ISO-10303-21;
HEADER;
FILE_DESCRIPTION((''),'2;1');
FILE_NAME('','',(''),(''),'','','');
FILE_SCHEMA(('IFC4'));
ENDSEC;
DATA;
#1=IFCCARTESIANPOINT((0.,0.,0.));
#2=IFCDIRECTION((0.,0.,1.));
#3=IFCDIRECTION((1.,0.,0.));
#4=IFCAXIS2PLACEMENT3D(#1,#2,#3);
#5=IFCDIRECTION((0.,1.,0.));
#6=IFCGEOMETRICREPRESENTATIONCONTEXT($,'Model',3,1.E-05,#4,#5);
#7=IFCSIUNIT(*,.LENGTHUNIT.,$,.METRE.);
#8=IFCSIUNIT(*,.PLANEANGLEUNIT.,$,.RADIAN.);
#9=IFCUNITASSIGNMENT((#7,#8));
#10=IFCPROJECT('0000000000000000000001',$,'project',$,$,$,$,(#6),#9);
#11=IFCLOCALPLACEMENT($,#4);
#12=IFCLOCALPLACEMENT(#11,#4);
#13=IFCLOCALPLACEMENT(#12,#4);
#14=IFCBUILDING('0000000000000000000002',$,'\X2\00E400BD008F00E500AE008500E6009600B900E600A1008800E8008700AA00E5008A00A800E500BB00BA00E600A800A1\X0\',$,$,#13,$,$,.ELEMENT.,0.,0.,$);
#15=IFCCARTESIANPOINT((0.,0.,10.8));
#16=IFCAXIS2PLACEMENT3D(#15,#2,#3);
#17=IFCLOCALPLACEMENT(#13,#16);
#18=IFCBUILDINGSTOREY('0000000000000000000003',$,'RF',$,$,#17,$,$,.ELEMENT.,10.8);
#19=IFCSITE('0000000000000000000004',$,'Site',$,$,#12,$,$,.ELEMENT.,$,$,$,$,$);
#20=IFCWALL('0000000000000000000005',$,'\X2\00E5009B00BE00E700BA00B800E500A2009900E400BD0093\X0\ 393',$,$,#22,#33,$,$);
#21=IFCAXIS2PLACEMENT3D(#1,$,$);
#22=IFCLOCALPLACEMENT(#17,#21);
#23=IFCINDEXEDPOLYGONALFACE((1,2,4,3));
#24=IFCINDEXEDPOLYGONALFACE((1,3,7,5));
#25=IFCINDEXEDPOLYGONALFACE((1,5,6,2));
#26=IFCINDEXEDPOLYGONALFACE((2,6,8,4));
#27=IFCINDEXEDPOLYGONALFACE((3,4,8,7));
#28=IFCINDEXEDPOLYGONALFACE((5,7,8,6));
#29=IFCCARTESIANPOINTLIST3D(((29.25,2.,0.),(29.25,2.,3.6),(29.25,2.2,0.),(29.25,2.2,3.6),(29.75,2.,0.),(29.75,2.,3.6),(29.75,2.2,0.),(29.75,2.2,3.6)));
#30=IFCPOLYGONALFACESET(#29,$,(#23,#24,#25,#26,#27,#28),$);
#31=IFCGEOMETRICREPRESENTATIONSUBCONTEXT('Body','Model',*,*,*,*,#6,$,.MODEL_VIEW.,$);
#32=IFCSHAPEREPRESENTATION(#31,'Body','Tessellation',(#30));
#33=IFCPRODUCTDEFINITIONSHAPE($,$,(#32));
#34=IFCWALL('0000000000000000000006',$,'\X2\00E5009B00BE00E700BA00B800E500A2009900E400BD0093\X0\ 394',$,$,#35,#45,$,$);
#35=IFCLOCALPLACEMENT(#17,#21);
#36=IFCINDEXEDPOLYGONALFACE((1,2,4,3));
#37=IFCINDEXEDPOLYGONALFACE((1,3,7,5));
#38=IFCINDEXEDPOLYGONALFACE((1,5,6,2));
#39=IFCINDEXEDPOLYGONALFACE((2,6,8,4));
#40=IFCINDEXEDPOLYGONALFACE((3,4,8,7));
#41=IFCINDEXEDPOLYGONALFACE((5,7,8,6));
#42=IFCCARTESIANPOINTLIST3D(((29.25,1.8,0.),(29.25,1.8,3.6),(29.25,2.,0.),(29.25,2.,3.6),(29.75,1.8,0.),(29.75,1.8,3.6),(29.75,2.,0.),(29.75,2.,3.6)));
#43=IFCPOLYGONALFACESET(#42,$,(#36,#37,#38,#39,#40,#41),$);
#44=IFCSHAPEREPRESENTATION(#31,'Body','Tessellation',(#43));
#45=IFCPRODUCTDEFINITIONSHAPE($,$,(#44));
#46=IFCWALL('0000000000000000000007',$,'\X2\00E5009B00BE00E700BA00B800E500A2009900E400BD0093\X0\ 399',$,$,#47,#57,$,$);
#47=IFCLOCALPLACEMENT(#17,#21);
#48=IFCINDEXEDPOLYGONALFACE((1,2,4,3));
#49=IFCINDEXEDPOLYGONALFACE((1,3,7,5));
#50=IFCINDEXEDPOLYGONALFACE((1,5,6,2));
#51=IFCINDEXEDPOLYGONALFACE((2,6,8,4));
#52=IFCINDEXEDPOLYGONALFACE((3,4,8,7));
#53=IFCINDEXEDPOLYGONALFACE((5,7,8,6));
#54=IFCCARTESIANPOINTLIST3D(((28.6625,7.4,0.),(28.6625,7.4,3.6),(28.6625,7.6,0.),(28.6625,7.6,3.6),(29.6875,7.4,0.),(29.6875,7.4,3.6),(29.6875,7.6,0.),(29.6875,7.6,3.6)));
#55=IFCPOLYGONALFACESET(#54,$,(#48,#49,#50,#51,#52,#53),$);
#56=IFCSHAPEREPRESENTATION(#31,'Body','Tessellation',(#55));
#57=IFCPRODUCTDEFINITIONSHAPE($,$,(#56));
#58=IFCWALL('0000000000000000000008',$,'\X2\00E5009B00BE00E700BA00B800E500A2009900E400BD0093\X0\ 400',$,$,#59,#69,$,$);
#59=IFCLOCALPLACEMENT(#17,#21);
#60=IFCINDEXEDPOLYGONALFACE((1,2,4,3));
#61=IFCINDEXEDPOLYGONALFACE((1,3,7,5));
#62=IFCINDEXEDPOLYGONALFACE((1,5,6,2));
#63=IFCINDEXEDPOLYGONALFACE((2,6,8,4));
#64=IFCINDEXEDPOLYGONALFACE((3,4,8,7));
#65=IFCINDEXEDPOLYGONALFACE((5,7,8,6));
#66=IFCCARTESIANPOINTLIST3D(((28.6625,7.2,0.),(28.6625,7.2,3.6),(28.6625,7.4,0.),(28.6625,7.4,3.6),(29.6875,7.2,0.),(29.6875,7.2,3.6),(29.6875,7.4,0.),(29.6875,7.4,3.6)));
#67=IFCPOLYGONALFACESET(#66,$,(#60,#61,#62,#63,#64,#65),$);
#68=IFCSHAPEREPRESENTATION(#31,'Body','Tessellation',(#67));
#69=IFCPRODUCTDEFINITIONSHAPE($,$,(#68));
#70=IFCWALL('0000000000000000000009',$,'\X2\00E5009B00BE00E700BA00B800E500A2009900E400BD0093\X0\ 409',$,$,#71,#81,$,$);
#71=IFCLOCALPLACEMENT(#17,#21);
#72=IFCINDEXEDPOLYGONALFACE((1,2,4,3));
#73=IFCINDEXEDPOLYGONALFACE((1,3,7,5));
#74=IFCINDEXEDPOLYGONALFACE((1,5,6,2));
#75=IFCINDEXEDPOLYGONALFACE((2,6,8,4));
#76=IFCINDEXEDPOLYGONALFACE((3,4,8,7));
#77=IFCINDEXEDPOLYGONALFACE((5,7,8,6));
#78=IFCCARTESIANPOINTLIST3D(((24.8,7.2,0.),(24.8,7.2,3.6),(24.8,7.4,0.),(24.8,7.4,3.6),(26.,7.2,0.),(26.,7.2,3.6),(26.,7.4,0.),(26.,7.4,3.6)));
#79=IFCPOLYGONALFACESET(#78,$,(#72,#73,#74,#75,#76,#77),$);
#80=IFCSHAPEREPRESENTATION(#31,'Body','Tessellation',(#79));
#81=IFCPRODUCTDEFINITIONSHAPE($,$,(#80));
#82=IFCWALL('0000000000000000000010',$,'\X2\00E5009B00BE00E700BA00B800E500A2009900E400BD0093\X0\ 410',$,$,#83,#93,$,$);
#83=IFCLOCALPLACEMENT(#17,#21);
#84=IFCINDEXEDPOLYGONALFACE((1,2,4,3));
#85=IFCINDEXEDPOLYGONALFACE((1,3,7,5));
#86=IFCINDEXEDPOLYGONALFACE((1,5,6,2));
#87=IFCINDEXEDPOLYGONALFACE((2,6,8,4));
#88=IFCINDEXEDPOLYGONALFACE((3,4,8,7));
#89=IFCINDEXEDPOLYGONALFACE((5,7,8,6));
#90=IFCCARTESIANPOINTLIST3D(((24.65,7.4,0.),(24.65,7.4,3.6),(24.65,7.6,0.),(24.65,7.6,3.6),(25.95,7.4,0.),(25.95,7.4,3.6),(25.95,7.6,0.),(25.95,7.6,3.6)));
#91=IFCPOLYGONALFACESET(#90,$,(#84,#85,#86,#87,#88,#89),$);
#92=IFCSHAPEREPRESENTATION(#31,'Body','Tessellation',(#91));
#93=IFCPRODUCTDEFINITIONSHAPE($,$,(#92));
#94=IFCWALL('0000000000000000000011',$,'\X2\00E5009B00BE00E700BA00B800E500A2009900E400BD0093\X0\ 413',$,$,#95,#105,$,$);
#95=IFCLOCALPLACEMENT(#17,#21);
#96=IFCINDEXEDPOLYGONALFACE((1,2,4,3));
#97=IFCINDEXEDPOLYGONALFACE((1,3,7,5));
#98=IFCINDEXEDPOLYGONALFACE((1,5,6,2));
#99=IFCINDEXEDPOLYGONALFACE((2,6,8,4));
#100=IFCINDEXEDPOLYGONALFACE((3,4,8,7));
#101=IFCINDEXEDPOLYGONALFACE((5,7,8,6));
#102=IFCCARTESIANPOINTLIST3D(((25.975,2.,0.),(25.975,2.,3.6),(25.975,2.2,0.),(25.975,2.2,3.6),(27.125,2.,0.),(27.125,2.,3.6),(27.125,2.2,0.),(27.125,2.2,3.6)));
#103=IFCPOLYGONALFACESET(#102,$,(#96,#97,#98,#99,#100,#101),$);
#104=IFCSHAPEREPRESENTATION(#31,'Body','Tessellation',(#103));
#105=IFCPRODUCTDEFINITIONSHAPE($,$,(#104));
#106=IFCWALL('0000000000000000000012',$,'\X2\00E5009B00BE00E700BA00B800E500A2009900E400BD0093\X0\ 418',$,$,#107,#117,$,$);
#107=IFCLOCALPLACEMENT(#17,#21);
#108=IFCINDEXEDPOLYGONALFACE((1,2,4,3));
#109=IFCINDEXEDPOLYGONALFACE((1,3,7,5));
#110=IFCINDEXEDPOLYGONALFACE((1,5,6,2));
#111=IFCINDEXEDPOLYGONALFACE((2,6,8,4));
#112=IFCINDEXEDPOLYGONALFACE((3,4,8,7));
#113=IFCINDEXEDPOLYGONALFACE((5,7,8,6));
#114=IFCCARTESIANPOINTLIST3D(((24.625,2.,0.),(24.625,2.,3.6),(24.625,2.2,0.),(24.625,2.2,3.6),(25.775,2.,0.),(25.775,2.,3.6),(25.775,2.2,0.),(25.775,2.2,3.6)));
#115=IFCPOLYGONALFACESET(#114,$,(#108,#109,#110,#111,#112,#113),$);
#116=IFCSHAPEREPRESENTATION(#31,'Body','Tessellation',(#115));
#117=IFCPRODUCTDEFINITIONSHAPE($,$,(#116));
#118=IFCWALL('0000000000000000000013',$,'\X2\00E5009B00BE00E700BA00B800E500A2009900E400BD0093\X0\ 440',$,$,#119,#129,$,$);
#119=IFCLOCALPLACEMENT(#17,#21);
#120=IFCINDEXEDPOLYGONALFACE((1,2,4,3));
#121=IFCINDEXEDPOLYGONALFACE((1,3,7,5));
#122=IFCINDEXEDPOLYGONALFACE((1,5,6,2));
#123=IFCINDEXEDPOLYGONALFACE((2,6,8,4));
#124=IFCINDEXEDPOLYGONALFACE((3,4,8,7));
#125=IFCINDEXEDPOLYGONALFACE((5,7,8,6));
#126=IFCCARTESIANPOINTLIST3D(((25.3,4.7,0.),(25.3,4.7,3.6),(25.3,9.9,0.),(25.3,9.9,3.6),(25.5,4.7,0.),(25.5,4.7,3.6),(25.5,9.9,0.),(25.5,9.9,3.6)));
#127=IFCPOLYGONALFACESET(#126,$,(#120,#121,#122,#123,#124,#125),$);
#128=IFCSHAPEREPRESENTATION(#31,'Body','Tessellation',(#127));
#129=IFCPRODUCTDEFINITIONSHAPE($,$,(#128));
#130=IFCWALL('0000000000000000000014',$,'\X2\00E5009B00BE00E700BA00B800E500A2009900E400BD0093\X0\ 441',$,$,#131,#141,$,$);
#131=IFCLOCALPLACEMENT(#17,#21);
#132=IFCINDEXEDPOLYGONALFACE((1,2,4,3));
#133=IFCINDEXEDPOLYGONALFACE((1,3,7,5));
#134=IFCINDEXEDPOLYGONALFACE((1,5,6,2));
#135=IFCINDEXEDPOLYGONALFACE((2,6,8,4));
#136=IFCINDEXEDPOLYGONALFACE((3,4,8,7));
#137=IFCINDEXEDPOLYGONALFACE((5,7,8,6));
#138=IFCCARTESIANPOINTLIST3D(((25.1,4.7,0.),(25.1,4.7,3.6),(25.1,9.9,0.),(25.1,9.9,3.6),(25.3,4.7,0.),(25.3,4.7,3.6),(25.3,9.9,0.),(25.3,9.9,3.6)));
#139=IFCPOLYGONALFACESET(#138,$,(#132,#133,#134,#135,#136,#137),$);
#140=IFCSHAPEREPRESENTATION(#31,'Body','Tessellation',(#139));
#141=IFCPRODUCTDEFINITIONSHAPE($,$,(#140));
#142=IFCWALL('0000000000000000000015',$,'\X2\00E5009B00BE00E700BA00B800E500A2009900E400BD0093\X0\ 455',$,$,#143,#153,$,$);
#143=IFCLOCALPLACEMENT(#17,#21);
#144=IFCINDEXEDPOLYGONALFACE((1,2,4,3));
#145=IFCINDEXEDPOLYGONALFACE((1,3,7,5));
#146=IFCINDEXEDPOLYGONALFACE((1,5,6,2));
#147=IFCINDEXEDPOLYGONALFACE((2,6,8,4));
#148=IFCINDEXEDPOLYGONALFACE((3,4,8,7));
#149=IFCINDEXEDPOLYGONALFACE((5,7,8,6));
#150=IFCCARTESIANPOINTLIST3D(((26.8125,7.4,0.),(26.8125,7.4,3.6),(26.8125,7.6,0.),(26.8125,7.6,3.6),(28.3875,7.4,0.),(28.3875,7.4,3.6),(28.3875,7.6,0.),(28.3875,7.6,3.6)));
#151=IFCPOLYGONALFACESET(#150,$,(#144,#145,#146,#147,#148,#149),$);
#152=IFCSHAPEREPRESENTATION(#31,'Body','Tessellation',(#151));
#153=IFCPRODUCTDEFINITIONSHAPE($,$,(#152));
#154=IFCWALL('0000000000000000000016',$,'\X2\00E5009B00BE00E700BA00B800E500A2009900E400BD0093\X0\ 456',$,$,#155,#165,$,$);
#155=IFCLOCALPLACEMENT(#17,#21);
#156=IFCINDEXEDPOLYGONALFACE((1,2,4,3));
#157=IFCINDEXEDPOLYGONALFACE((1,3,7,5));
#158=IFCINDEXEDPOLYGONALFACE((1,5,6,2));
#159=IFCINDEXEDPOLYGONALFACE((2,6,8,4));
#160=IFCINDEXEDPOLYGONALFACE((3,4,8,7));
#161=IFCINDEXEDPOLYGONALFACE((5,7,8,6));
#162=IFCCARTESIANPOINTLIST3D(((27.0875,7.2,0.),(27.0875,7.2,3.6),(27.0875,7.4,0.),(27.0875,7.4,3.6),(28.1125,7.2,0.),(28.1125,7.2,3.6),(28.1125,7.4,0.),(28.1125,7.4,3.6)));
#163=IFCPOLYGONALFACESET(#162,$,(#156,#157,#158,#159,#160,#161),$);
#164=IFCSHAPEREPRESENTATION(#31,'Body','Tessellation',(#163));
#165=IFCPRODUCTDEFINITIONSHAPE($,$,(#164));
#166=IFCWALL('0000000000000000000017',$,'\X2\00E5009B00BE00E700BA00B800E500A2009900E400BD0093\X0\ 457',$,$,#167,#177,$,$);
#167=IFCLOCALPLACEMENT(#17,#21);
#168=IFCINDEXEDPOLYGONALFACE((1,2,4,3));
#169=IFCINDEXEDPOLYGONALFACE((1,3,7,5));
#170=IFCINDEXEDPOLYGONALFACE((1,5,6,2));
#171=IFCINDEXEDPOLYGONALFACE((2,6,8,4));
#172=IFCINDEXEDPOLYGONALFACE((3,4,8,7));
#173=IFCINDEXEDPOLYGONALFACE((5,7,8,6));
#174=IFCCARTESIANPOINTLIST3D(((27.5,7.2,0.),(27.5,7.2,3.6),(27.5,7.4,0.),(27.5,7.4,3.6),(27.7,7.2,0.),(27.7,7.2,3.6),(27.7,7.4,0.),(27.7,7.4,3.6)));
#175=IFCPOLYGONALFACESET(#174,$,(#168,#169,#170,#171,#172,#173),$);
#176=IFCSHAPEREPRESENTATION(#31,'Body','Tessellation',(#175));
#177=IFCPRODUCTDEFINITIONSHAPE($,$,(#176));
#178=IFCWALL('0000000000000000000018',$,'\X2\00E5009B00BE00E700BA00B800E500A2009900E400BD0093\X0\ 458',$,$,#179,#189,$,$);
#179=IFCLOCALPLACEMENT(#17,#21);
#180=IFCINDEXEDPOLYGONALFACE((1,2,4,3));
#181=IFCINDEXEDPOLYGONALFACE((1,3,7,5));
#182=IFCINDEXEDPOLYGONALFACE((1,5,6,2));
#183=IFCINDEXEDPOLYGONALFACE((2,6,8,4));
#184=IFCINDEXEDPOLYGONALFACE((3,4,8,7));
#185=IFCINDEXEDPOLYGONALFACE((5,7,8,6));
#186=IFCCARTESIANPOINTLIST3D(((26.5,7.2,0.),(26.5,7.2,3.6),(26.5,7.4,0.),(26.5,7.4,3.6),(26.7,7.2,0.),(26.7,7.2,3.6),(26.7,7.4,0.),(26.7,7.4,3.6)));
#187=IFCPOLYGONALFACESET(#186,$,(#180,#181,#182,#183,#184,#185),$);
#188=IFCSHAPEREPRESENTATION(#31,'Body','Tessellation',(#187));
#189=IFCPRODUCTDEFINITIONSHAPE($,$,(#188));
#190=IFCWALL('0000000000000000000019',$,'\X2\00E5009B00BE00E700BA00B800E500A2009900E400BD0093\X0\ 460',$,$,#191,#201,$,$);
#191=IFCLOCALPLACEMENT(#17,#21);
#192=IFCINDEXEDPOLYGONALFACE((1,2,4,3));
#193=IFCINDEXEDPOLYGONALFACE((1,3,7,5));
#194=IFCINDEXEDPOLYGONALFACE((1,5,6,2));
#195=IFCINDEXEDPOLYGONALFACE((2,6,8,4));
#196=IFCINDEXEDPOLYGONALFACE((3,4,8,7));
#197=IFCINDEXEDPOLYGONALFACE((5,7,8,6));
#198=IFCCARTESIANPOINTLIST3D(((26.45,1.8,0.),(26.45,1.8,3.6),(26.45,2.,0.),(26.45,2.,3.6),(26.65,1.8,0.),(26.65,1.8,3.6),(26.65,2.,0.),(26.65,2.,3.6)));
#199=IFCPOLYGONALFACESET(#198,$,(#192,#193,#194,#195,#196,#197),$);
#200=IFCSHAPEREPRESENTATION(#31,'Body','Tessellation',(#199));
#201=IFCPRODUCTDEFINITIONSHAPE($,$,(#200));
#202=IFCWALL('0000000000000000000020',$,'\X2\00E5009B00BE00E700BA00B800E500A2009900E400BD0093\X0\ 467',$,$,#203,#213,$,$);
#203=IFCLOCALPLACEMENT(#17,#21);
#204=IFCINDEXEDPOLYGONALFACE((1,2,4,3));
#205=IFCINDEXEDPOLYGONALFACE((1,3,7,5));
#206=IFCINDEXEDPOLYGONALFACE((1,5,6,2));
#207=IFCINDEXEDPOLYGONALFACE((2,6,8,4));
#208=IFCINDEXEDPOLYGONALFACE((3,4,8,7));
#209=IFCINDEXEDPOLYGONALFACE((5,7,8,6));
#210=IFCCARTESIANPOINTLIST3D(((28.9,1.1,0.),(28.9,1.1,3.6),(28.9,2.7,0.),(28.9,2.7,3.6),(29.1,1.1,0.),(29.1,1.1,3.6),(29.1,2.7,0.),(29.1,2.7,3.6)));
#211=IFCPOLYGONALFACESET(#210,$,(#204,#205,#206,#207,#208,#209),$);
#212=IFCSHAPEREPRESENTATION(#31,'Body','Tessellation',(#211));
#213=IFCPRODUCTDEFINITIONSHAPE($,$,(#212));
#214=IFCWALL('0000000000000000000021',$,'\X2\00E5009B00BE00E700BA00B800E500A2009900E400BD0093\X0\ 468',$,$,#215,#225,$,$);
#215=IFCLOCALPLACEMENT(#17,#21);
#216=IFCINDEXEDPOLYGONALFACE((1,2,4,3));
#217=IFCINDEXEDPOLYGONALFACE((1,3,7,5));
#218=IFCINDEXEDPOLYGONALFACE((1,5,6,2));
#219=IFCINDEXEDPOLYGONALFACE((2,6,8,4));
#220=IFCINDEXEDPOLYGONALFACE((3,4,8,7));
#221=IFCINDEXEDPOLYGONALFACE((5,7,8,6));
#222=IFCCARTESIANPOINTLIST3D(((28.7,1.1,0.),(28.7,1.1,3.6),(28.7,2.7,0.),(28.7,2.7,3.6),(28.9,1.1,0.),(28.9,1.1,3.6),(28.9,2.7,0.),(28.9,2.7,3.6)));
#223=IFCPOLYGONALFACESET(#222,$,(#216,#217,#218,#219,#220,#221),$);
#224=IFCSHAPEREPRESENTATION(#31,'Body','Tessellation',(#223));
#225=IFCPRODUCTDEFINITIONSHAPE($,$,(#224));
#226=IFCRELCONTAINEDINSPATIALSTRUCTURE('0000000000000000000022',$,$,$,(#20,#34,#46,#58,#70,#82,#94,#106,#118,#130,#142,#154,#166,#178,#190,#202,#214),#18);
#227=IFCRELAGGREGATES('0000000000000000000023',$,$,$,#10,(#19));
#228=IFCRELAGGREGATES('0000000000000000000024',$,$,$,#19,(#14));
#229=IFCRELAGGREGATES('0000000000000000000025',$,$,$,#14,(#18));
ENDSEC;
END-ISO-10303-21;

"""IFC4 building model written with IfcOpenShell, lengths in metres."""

from ifc_helpers import new_model, si_unit, direction, frame, frame_2d, origin_with_axes, place, context, subcontext, project, spatial, rectangle, extrude, element, save


model = new_model("IFC4")

# Units and contexts
model_context = context("Model", 3, precision=1e-05, world=origin_with_axes(), true_north=direction((0.0, 1.0, 0.0)))
body_context = subcontext(model_context, "Body", "Model", "MODEL_VIEW")
ifc_project = project(units=[si_unit("LENGTHUNIT", "METRE"), si_unit("PLANEANGLEUNIT", "RADIAN")], contexts=[model_context])

# Site, building, storey
placement = place(None, origin_with_axes())
site_placement = place(placement, origin_with_axes())
site = spatial("IfcSite", under=ifc_project, at=site_placement, Name="Site", CompositionType="ELEMENT")
building_placement = place(site_placement, origin_with_axes())
building = spatial("IfcBuilding", under=site, at=building_placement, Name="ä½\u008få®\u0085æ\u0096¹æ¡\u0088è\u0087ªå\u008a¨å»ºæ¨¡", CompositionType="ELEMENT", ElevationOfRefHeight=0.0, ElevationOfTerrain=0.0)
storey_placement = place(building_placement, frame((0.0, 0.0, 10.8), z_axis=(0.0, 0.0, 1.0), x_axis=(1.0, 0.0, 0.0)))
storey = spatial("IfcBuildingStorey", under=building, at=storey_placement, Name="RF", CompositionType="ELEMENT", Elevation=10.8)

# Walls
for number, where, z_axis, x_axis, name in (
    (1, (29.5, 2.1, 0.0), (0.0, 0.0, 1.0), (-1.0, 0.0, 0.0), "å\u009b¾çº¸å¢\u0099ä½\u0093 393"),
    (2, (29.5, 1.9, 0.0), (0.0, 0.0, 1.0), (-1.0, 0.0, 0.0), "å\u009b¾çº¸å¢\u0099ä½\u0093 394"),
):
    element("IfcWall", number, at=place(storey_placement, frame(where, z_axis=z_axis, x_axis=x_axis)), inside=storey, Name=name, context=body_context, shape_type="SweptSolid", body=[
        extrude(rectangle(XDim=0.5, YDim=0.2, at=frame_2d((0.0, 0.0), x_axis=(1.0, 0.0, 0.0))), frame((0.0, 0.0, 0.0), z_axis=(0.0, 0.0, 1.0)), (0.0, 0.0, 1.0), 3.6),
    ])
for number, where, z_axis, x_axis, name in (
    (3, (29.175, 7.5, 0.0), (0.0, 0.0, 1.0), (1.0, 0.0, 0.0), "å\u009b¾çº¸å¢\u0099ä½\u0093 399"),
    (4, (29.175, 7.3, 0.0), (0.0, 0.0, 1.0), (1.0, 0.0, 0.0), "å\u009b¾çº¸å¢\u0099ä½\u0093 400"),
):
    element("IfcWall", number, at=place(storey_placement, frame(where, z_axis=z_axis, x_axis=x_axis)), inside=storey, Name=name, context=body_context, shape_type="SweptSolid", body=[
        extrude(rectangle(XDim=1.025, YDim=0.2, at=frame_2d((0.0, 0.0), x_axis=(1.0, 0.0, 0.0))), frame((0.0, 0.0, 0.0), z_axis=(0.0, 0.0, 1.0)), (0.0, 0.0, 1.0), 3.6),
    ])
wall_1_placement = place(storey_placement, frame((25.4, 7.3, 0.0), z_axis=(0.0, 0.0, 1.0), x_axis=(1.0, 0.0, 0.0)))
element("IfcWall", 5, at=wall_1_placement, inside=storey, Name="å\u009b¾çº¸å¢\u0099ä½\u0093 409", context=body_context, shape_type="SweptSolid", body=[
    extrude(rectangle(XDim=1.2, YDim=0.2, at=frame_2d((0.0, 0.0), x_axis=(1.0, 0.0, 0.0))), frame((0.0, 0.0, 0.0), z_axis=(0.0, 0.0, 1.0)), (0.0, 0.0, 1.0), 3.6),
])
wall_2_placement = place(storey_placement, frame((25.3, 7.5, 0.0), z_axis=(0.0, 0.0, 1.0), x_axis=(1.0, 0.0, 0.0)))
element("IfcWall", 6, at=wall_2_placement, inside=storey, Name="å\u009b¾çº¸å¢\u0099ä½\u0093 410", context=body_context, shape_type="SweptSolid", body=[
    extrude(rectangle(XDim=1.3, YDim=0.2, at=frame_2d((0.0, 0.0), x_axis=(1.0, 0.0, 0.0))), frame((0.0, 0.0, 0.0), z_axis=(0.0, 0.0, 1.0)), (0.0, 0.0, 1.0), 3.6),
])
for number, where, z_axis, x_axis, name in (
    (7, (26.55, 2.1, 0.0), (0.0, 0.0, 1.0), (-1.0, 0.0, 0.0), "å\u009b¾çº¸å¢\u0099ä½\u0093 413"),
    (8, (25.2, 2.1, 0.0), (0.0, 0.0, 1.0), (-1.0, 0.0, 0.0), "å\u009b¾çº¸å¢\u0099ä½\u0093 418"),
):
    element("IfcWall", number, at=place(storey_placement, frame(where, z_axis=z_axis, x_axis=x_axis)), inside=storey, Name=name, context=body_context, shape_type="SweptSolid", body=[
        extrude(rectangle(XDim=1.15, YDim=0.2, at=frame_2d((0.0, 0.0), x_axis=(1.0, 0.0, 0.0))), frame((0.0, 0.0, 0.0), z_axis=(0.0, 0.0, 1.0)), (0.0, 0.0, 1.0), 3.6),
    ])
for number, where, z_axis, x_axis, name in (
    (9, (25.4, 7.3, 0.0), (0.0, 0.0, 1.0), (0.0, -1.0, 0.0), "å\u009b¾çº¸å¢\u0099ä½\u0093 440"),
    (10, (25.2, 7.3, 0.0), (0.0, 0.0, 1.0), (0.0, -1.0, 0.0), "å\u009b¾çº¸å¢\u0099ä½\u0093 441"),
):
    element("IfcWall", number, at=place(storey_placement, frame(where, z_axis=z_axis, x_axis=x_axis)), inside=storey, Name=name, context=body_context, shape_type="SweptSolid", body=[
        extrude(rectangle(XDim=5.2, YDim=0.2, at=frame_2d((0.0, 0.0), x_axis=(1.0, 0.0, 0.0))), frame((0.0, 0.0, 0.0), z_axis=(0.0, 0.0, 1.0)), (0.0, 0.0, 1.0), 3.6),
    ])
wall_3_placement = place(storey_placement, frame((27.6, 7.5, 0.0), z_axis=(0.0, 0.0, 1.0), x_axis=(1.0, 0.0, 0.0)))
element("IfcWall", 11, at=wall_3_placement, inside=storey, Name="å\u009b¾çº¸å¢\u0099ä½\u0093 455", context=body_context, shape_type="SweptSolid", body=[
    extrude(rectangle(XDim=1.575, YDim=0.2, at=frame_2d((0.0, 0.0), x_axis=(1.0, 0.0, 0.0))), frame((0.0, 0.0, 0.0), z_axis=(0.0, 0.0, 1.0)), (0.0, 0.0, 1.0), 3.6),
])
wall_4_placement = place(storey_placement, frame((27.6, 7.3, 0.0), z_axis=(0.0, 0.0, 1.0), x_axis=(1.0, 0.0, 0.0)))
element("IfcWall", 12, at=wall_4_placement, inside=storey, Name="å\u009b¾çº¸å¢\u0099ä½\u0093 456", context=body_context, shape_type="SweptSolid", body=[
    extrude(rectangle(XDim=1.025, YDim=0.2, at=frame_2d((0.0, 0.0), x_axis=(1.0, 0.0, 0.0))), frame((0.0, 0.0, 0.0), z_axis=(0.0, 0.0, 1.0)), (0.0, 0.0, 1.0), 3.6),
])
for number, where, z_axis, x_axis, name in (
    (13, (27.6, 7.3, 0.0), (0.0, 0.0, 1.0), (0.0, 1.0, 0.0), "å\u009b¾çº¸å¢\u0099ä½\u0093 457"),
    (14, (26.6, 7.3, 0.0), (0.0, 0.0, 1.0), (0.0, 1.0, 0.0), "å\u009b¾çº¸å¢\u0099ä½\u0093 458"),
    (15, (26.55, 1.9, 0.0), (0.0, 0.0, 1.0), (0.0, 1.0, 0.0), "å\u009b¾çº¸å¢\u0099ä½\u0093 460"),
):
    element("IfcWall", number, at=place(storey_placement, frame(where, z_axis=z_axis, x_axis=x_axis)), inside=storey, Name=name, context=body_context, shape_type="SweptSolid", body=[
        extrude(rectangle(XDim=0.2, YDim=0.2, at=frame_2d((0.0, 0.0), x_axis=(1.0, 0.0, 0.0))), frame((0.0, 0.0, 0.0), z_axis=(0.0, 0.0, 1.0)), (0.0, 0.0, 1.0), 3.6),
    ])
for number, where, z_axis, x_axis, name in (
    (16, (29.0, 1.9, 0.0), (0.0, 0.0, 1.0), (0.0, -1.0, 0.0), "å\u009b¾çº¸å¢\u0099ä½\u0093 467"),
    (17, (28.8, 1.9, 0.0), (0.0, 0.0, 1.0), (0.0, -1.0, 0.0), "å\u009b¾çº¸å¢\u0099ä½\u0093 468"),
):
    element("IfcWall", number, at=place(storey_placement, frame(where, z_axis=z_axis, x_axis=x_axis)), inside=storey, Name=name, context=body_context, shape_type="SweptSolid", body=[
        extrude(rectangle(XDim=1.6, YDim=0.2, at=frame_2d((0.0, 0.0), x_axis=(1.0, 0.0, 0.0))), frame((0.0, 0.0, 0.0), z_axis=(0.0, 0.0, 1.0)), (0.0, 0.0, 1.0), 3.6),
    ])

save(model, "model.ifc")
